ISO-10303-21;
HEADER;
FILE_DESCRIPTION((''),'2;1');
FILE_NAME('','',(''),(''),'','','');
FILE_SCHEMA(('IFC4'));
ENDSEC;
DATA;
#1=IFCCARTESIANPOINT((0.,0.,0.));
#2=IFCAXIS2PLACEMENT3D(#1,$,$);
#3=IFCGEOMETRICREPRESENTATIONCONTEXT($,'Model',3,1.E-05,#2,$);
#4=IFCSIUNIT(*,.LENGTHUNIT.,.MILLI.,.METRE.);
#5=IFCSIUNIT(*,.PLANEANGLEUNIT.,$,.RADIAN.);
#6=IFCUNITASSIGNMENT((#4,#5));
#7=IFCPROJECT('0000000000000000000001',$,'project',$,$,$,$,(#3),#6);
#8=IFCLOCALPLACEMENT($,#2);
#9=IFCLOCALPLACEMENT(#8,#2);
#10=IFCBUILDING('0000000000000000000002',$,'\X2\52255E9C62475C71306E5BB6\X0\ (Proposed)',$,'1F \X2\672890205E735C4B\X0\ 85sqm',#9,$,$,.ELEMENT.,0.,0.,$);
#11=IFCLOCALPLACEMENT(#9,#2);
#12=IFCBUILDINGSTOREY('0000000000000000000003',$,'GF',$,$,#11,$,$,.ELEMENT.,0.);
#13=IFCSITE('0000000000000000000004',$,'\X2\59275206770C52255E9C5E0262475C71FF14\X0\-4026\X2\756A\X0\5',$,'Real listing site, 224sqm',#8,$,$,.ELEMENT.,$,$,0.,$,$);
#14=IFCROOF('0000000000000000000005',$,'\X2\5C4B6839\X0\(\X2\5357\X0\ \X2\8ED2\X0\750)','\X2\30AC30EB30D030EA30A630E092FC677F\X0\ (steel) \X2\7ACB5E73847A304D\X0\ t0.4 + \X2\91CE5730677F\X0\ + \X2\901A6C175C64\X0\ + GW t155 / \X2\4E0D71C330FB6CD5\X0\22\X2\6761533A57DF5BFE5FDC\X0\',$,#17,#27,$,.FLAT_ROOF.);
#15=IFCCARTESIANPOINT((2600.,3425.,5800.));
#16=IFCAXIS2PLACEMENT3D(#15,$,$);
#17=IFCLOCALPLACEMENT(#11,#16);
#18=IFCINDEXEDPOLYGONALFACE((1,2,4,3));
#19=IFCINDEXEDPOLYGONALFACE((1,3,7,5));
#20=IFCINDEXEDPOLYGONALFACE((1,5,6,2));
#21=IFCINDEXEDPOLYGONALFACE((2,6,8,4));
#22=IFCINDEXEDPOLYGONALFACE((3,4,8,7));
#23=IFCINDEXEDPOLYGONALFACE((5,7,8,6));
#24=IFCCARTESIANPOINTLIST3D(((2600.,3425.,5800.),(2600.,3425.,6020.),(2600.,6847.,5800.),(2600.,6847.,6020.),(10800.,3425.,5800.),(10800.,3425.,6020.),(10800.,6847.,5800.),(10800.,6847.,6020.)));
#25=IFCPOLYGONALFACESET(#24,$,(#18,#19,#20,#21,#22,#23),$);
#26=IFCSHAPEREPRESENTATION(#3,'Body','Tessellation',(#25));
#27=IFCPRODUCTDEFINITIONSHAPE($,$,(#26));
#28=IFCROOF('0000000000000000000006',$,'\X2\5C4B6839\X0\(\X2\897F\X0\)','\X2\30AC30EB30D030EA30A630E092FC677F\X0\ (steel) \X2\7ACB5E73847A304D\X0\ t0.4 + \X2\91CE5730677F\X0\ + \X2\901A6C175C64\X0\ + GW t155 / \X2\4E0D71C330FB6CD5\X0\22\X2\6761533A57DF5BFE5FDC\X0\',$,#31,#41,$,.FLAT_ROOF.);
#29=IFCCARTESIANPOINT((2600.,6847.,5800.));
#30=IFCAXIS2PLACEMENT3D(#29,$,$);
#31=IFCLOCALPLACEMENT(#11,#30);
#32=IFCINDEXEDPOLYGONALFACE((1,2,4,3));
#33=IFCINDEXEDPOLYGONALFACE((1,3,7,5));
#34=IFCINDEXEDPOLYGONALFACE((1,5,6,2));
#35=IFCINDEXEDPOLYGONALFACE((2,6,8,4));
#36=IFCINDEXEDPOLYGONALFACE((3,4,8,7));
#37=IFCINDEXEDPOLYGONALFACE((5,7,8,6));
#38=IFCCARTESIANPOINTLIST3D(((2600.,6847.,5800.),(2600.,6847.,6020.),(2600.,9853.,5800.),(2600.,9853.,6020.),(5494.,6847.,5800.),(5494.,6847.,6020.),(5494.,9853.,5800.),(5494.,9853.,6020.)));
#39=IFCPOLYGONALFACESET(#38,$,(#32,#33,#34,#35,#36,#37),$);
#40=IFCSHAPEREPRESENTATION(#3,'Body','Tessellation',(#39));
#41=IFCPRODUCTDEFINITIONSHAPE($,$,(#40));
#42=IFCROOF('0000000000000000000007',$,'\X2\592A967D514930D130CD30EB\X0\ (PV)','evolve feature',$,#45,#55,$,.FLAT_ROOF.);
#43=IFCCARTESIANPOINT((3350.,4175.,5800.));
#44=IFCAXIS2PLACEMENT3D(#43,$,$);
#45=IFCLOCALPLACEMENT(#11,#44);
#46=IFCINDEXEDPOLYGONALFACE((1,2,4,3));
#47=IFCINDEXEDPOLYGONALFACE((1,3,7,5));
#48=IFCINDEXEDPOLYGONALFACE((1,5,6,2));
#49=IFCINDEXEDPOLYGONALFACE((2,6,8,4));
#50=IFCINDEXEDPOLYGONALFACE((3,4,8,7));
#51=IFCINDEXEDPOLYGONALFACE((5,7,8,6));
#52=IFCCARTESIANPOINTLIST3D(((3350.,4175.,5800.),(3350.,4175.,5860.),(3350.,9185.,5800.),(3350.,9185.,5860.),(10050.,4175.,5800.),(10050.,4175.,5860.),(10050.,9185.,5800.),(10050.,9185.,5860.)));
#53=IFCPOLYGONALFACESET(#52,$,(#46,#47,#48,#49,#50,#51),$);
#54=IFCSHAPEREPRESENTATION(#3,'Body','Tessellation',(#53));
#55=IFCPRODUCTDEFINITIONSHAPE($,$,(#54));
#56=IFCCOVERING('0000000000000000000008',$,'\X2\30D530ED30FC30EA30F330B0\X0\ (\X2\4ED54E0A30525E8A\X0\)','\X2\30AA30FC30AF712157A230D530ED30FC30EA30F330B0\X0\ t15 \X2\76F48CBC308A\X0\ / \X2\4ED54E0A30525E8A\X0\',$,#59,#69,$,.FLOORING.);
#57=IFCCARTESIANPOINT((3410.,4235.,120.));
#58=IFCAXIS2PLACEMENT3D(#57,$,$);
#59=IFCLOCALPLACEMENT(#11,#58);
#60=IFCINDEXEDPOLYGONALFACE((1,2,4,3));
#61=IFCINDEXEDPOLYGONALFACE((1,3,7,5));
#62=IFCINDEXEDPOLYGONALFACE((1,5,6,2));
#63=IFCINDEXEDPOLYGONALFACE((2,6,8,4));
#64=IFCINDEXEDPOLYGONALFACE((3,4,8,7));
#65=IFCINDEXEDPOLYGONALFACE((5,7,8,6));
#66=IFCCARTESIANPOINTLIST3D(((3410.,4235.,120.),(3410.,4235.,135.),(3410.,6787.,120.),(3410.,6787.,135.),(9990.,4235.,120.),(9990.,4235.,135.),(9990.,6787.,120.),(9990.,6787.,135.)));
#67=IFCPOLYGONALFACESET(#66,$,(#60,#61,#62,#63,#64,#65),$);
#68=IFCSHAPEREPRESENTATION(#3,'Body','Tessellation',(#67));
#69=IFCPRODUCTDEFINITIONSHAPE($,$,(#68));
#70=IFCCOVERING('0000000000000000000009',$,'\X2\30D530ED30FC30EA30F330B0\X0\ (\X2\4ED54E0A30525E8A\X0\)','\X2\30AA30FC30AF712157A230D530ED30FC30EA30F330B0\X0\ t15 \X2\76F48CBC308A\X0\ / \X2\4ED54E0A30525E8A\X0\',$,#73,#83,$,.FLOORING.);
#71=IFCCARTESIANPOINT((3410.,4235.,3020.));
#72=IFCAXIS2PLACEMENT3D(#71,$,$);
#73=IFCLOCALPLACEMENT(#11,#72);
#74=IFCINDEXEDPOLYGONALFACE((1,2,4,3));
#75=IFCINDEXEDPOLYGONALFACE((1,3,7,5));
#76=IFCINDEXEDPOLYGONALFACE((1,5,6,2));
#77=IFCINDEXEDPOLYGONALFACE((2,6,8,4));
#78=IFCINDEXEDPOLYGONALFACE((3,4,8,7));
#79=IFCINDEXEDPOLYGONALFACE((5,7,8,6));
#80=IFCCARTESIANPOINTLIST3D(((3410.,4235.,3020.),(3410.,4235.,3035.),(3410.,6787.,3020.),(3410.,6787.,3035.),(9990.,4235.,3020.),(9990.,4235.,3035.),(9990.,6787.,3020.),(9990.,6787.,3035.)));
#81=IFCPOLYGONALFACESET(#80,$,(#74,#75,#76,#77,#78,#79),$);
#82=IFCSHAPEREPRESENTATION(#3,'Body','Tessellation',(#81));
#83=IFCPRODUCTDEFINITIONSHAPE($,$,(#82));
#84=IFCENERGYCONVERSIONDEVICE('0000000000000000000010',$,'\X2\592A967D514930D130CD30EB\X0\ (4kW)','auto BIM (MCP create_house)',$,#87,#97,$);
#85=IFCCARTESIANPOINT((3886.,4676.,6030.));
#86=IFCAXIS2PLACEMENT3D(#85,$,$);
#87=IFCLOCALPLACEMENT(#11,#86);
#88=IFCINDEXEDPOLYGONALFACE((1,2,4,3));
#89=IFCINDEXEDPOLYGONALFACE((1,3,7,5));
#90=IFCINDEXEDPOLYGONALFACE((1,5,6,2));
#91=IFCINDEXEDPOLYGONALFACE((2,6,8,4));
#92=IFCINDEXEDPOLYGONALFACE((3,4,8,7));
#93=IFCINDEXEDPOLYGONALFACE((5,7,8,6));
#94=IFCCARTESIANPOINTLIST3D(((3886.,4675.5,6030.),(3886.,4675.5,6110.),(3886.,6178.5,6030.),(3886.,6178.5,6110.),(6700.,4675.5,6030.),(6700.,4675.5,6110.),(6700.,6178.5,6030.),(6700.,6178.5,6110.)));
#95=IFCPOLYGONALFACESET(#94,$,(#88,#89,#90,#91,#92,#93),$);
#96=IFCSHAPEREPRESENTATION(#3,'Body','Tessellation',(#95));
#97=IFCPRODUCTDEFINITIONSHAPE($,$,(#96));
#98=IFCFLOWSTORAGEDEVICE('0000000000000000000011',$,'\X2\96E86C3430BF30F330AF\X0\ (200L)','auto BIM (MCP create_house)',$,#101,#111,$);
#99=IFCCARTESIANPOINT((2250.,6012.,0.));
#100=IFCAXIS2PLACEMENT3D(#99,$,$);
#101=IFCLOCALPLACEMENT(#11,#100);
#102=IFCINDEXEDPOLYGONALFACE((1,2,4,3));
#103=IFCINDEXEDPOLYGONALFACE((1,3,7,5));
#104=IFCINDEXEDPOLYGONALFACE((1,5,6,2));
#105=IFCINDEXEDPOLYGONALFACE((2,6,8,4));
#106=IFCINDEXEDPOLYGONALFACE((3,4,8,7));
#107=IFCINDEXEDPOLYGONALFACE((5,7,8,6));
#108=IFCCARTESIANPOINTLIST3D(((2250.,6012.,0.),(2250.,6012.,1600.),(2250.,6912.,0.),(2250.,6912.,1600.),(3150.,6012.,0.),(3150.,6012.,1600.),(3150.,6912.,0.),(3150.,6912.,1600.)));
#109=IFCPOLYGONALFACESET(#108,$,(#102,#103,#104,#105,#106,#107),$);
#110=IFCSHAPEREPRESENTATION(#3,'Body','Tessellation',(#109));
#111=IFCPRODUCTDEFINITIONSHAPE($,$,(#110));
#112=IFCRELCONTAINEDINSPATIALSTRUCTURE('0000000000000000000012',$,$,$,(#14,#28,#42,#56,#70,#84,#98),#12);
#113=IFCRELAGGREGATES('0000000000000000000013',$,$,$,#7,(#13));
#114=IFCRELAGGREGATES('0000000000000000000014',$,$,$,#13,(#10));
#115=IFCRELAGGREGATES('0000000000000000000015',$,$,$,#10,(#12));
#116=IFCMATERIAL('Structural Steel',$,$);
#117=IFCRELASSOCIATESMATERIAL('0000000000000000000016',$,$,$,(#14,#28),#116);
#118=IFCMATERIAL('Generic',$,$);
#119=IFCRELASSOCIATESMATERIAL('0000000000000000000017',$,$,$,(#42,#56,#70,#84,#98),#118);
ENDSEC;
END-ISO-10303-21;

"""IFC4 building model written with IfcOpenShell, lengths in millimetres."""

from ifc_helpers import new_model, si_unit, frame, frame_2d, origin, place, context, project, spatial, rectangle, extrude, material, element, save


model = new_model("IFC4")

# Units and contexts
model_context = context("Model", 3, precision=1e-05, world=origin())
ifc_project = project(units=[si_unit("LENGTHUNIT", "METRE", prefix="MILLI"), si_unit("PLANEANGLEUNIT", "RADIAN")], contexts=[model_context])

# Site, building, storey
site_placement = place(None, origin())
site = spatial("IfcSite", under=ifc_project, at=site_placement, Name="大分県別府市扇山４-4026番5", ObjectType="Real listing site, 224sqm", CompositionType="ELEMENT", RefElevation=0.0)
building_placement = place(site_placement, origin())
building = spatial("IfcBuilding", under=site, at=building_placement, Name="別府扇山の家 (Proposed)", ObjectType="1F 木造平屋 85sqm", CompositionType="ELEMENT", ElevationOfRefHeight=0.0, ElevationOfTerrain=0.0)
storey_placement = place(building_placement, origin())
storey = spatial("IfcBuildingStorey", under=building, at=storey_placement, Name="GF", CompositionType="ELEMENT", Elevation=0.0)

# Shared definitions
ifc_material_1 = material(Name="Generic")

# Roofs
ifc_material_2 = material(Name="Structural Steel")
roof_1_placement = place(storey_placement, frame((2600.0, 3425.0, 5800.0)))
element("IfcRoof", 1, at=roof_1_placement, inside=storey, material=ifc_material_2, Name="屋根(南 軒750)", Description="ガルバリウム鋼板 (steel) 立平葺き t0.4 + 野地板 + 通気層 + GW t155 / 不燃・法22条区域対応", PredefinedType="FLAT_ROOF", context=model_context, shape_type="SweptSolid", body=[
    extrude(rectangle(XDim=8200.0, YDim=3422.0, at=frame_2d((4100.0, 1711.0))), frame((2600.0, 3425.0, 5800.0)), (0.0, 0.0, 1.0), 220.0),
])
roof_2_placement = place(storey_placement, frame((2600.0, 6847.0, 5800.0)))
element("IfcRoof", 2, at=roof_2_placement, inside=storey, material=ifc_material_2, Name="屋根(西)", Description="ガルバリウム鋼板 (steel) 立平葺き t0.4 + 野地板 + 通気層 + GW t155 / 不燃・法22条区域対応", PredefinedType="FLAT_ROOF", context=model_context, shape_type="SweptSolid", body=[
    extrude(rectangle(XDim=2894.0, YDim=3006.0, at=frame_2d((1447.0, 1503.0))), frame((2600.0, 6847.0, 5800.0)), (0.0, 0.0, 1.0), 220.0),
])
roof_3_placement = place(storey_placement, frame((3350.0, 4175.0, 5800.0)))
element("IfcRoof", 3, at=roof_3_placement, inside=storey, material=ifc_material_1, Name="太陽光パネル (PV)", Description="evolve feature", PredefinedType="FLAT_ROOF", context=model_context, shape_type="SweptSolid", body=[
    extrude(rectangle(XDim=6700.0, YDim=5010.0, at=frame_2d((3350.0, 2505.0))), frame((3350.0, 4175.0, 5800.0)), (0.0, 0.0, 1.0), 60.0),
])

# Coverings
covering_1_placement = place(storey_placement, frame((3410.0, 4235.0, 120.0)))
element("IfcCovering", 4, at=covering_1_placement, inside=storey, material=ifc_material_1, Name="フローリング (仕上げ床)", Description="オーク無垢フローリング t15 直貼り / 仕上げ床", PredefinedType="FLOORING", context=model_context, shape_type="SweptSolid", body=[
    extrude(rectangle(XDim=6580.0, YDim=2552.0, at=frame_2d((3290.0, 1276.0))), frame((3410.0, 4235.0, 120.0)), (0.0, 0.0, 1.0), 15.0),
])
covering_2_placement = place(storey_placement, frame((3410.0, 4235.0, 3020.0)))
element("IfcCovering", 5, at=covering_2_placement, inside=storey, material=ifc_material_1, Name="フローリング (仕上げ床)", Description="オーク無垢フローリング t15 直貼り / 仕上げ床", PredefinedType="FLOORING", context=model_context, shape_type="SweptSolid", body=[
    extrude(rectangle(XDim=6580.0, YDim=2552.0, at=frame_2d((3290.0, 1276.0))), frame((3410.0, 4235.0, 3020.0)), (0.0, 0.0, 1.0), 15.0),
])

# Energy conversion device
energy_conversion_device_placement = place(storey_placement, frame((3886.0, 4676.0, 6030.0)))
element("IfcEnergyConversionDevice", 6, at=energy_conversion_device_placement, inside=storey, material=ifc_material_1, Name="太陽光パネル (4kW)", Description="auto BIM (MCP create_house)", context=model_context, shape_type="SweptSolid", body=[
    extrude(rectangle(XDim=2814.0, YDim=1503.0, at=frame_2d((1407.0, 751.0))), frame((3886.0, 4676.0, 6030.0)), (0.0, 0.0, 1.0), 80.0),
])

# Flow storage device
flow_storage_device_placement = place(storey_placement, frame((2250.0, 6012.0, 0.0)))
element("IfcFlowStorageDevice", 7, at=flow_storage_device_placement, inside=storey, material=ifc_material_1, Name="雨水タンク (200L)", Description="auto BIM (MCP create_house)", context=model_context, shape_type="SweptSolid", body=[
    extrude(rectangle(XDim=900.0, YDim=900.0, at=frame_2d((450.0, 450.0))), frame((2250.0, 6012.0, 0.0)), (0.0, 0.0, 1.0), 1600.0),
])

save(model, "model.ifc")
